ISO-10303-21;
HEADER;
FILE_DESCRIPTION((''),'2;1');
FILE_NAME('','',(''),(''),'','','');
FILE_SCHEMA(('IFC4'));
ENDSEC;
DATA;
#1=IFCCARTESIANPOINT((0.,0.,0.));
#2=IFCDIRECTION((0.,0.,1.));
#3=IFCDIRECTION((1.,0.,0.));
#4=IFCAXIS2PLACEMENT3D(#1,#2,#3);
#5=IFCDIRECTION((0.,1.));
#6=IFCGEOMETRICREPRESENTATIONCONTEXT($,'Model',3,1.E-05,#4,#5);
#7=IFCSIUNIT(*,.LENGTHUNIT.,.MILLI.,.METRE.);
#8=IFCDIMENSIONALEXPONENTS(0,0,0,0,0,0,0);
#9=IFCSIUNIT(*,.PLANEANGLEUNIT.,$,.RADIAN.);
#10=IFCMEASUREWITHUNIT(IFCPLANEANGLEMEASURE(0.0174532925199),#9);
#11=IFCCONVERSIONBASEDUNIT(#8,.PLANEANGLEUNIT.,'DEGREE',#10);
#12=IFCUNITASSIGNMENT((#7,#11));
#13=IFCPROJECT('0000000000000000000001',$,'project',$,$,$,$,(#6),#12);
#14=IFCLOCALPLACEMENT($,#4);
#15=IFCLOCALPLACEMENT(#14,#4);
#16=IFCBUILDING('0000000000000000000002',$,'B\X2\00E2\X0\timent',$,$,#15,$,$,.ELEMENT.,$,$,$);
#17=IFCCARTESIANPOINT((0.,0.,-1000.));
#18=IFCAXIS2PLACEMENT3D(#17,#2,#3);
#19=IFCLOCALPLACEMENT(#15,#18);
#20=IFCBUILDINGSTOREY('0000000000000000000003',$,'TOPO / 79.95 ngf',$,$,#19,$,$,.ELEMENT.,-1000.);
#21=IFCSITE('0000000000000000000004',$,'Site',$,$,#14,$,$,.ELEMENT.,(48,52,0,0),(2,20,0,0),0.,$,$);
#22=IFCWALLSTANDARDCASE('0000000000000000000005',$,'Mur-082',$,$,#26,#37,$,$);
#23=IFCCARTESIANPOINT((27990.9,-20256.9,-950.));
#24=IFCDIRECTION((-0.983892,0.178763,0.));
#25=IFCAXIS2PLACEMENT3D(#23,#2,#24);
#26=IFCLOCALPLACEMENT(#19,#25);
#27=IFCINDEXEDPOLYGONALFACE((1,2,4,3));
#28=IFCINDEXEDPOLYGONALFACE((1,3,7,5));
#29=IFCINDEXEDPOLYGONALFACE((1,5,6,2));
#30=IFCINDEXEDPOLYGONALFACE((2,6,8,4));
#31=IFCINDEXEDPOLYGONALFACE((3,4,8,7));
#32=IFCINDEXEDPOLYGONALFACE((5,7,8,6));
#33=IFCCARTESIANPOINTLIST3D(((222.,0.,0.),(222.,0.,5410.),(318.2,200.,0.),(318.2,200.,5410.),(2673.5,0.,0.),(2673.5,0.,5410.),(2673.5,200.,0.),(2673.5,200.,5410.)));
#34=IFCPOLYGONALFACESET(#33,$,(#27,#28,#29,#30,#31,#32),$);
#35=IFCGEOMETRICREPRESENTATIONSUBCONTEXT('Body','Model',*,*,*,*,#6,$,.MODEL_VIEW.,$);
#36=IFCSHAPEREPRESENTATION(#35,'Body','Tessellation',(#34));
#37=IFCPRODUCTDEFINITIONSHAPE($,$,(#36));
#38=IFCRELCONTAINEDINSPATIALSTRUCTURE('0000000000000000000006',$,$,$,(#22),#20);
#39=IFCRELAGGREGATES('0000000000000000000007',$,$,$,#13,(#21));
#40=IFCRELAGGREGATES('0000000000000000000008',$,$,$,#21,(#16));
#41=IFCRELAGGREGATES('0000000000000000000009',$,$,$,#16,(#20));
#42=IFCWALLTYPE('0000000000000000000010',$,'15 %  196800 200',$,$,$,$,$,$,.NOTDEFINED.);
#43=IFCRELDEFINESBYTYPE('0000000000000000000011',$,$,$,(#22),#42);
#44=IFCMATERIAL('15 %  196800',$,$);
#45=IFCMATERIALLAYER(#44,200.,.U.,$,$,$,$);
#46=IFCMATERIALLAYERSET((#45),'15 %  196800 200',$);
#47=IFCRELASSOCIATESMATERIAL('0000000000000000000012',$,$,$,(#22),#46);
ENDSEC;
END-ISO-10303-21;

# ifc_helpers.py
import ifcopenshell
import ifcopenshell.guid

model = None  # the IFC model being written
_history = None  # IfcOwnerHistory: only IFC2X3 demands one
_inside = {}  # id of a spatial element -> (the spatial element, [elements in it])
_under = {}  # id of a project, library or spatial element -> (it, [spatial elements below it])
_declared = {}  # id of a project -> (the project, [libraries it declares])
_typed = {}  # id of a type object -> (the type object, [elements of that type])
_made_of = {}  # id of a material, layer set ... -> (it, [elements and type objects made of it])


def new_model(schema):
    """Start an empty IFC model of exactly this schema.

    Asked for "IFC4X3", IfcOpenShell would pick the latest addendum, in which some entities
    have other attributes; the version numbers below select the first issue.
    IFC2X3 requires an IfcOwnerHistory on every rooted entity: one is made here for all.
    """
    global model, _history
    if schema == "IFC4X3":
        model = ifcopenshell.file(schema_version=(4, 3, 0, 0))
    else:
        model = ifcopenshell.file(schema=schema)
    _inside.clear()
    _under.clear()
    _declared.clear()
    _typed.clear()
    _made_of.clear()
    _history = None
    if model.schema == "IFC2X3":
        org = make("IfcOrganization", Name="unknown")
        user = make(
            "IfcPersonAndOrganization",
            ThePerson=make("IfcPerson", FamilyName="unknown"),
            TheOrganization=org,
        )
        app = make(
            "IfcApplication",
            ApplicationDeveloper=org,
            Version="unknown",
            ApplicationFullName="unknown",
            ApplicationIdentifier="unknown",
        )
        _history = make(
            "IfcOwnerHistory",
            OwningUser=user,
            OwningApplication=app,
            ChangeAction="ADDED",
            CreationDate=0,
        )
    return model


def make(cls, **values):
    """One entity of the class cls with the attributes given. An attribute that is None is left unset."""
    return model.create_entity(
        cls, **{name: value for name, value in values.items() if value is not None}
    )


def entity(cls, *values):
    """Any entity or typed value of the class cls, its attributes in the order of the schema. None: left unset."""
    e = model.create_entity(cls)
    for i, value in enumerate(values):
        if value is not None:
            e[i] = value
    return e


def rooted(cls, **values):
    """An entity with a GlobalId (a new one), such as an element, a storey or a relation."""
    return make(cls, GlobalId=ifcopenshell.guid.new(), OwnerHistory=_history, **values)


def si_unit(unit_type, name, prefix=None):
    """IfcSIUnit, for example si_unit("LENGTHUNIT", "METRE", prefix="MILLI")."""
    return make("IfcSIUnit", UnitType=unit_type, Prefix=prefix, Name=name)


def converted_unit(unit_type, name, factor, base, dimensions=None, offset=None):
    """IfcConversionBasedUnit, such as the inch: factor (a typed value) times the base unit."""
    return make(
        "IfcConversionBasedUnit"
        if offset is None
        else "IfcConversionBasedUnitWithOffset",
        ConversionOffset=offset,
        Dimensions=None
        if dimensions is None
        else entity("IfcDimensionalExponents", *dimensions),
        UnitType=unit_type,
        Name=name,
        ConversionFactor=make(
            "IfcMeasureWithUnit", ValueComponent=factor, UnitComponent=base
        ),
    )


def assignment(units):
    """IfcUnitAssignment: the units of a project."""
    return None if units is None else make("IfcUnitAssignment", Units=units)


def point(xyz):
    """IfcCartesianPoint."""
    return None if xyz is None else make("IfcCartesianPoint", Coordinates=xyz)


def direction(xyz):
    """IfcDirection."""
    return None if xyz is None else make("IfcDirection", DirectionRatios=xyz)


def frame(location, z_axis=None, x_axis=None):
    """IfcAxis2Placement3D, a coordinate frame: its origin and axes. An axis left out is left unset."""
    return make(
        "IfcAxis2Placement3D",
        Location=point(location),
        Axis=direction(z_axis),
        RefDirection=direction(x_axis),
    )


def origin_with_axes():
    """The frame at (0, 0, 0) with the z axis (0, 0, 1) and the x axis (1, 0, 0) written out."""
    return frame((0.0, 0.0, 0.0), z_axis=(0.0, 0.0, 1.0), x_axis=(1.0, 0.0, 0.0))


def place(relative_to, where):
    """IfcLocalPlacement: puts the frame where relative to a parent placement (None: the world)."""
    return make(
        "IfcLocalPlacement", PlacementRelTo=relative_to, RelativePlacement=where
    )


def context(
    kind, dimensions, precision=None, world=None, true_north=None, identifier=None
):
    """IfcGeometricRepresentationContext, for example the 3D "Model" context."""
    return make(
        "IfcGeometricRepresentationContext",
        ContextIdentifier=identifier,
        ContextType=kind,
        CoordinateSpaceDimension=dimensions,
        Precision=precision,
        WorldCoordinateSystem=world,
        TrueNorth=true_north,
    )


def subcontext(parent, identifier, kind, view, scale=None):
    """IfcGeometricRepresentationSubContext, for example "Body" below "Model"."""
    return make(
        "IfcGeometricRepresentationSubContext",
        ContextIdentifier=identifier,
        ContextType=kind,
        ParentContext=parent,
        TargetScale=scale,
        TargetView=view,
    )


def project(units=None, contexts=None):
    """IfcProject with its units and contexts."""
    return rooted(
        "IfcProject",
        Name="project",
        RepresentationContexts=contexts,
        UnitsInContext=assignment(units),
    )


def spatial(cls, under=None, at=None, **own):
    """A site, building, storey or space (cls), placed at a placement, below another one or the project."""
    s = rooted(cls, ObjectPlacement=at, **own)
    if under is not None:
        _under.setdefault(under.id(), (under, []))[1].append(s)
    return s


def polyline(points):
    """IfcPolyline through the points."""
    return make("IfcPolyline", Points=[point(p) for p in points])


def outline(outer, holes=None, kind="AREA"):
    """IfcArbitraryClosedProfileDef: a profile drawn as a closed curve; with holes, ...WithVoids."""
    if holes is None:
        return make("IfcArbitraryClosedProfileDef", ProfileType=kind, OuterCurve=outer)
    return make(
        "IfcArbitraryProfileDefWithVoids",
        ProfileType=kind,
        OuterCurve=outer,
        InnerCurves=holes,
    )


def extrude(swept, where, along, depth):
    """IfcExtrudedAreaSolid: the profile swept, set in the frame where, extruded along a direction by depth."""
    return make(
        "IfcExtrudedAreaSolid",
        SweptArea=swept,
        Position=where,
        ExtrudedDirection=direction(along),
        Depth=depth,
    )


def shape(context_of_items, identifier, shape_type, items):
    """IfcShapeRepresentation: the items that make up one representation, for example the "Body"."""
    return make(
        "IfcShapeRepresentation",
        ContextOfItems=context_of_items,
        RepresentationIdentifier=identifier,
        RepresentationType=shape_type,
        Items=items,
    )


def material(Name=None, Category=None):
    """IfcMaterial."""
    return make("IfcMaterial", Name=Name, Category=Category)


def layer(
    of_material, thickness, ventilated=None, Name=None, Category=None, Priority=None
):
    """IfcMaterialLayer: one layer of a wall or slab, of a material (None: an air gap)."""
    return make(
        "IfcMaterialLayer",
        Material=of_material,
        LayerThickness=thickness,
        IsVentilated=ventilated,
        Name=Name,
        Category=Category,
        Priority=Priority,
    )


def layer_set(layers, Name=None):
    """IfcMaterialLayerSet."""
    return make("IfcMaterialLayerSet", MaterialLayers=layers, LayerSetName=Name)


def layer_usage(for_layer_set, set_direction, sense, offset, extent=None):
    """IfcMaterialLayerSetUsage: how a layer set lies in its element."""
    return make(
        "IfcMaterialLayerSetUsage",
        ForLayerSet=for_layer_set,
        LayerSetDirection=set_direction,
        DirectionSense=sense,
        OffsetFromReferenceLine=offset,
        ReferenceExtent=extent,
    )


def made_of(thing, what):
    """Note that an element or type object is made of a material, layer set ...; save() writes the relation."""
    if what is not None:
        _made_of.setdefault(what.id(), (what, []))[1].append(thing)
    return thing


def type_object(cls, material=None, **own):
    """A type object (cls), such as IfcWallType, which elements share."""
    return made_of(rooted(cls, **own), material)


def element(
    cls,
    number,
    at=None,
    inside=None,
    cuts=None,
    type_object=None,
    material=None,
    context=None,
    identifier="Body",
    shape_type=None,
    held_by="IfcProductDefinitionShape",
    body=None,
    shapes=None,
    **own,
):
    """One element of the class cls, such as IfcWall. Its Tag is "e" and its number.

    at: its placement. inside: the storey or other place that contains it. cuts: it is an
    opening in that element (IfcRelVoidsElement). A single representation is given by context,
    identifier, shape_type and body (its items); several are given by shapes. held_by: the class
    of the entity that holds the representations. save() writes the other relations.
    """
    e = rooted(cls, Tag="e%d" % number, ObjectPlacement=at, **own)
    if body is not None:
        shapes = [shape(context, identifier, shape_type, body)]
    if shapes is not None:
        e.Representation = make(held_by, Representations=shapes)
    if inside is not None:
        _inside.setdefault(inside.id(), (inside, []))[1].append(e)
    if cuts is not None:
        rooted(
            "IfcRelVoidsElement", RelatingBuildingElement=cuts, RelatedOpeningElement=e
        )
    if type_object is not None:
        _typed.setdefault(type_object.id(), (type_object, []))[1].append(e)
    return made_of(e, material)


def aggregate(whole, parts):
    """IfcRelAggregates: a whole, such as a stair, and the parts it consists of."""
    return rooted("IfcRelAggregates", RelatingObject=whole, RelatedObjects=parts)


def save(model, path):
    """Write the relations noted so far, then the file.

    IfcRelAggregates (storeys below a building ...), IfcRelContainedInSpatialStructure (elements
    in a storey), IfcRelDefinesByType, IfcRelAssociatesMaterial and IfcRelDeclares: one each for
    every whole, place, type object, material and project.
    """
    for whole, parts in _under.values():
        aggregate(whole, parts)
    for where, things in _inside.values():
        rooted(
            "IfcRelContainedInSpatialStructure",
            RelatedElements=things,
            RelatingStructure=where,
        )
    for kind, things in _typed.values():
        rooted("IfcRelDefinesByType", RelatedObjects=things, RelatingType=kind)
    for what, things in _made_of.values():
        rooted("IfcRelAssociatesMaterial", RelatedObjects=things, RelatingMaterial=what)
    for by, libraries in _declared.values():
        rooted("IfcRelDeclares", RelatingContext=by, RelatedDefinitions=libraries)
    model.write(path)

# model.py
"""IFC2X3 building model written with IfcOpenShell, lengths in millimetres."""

from ifc_helpers import new_model, entity, si_unit, converted_unit, direction, frame, origin_with_axes, place, context, subcontext, project, spatial, polyline, outline, extrude, material, layer, layer_set, layer_usage, type_object, element, save


model = new_model("IFC2X3")

# Units and contexts
model_context = context("Model", 3, precision=1e-05, world=origin_with_axes(), true_north=direction((0.0, 1.0)))
body_context = subcontext(model_context, "Body", "Model", "MODEL_VIEW")
ifc_project = project(units=[si_unit("LENGTHUNIT", "METRE", prefix="MILLI"), converted_unit("PLANEANGLEUNIT", "DEGREE", entity("IfcPlaneAngleMeasure", 0.0174532925199), si_unit("PLANEANGLEUNIT", "RADIAN"), dimensions=[0, 0, 0, 0, 0, 0, 0])], contexts=[model_context])

# Site, building, storey
site_placement = place(None, origin_with_axes())
site = spatial("IfcSite", under=ifc_project, at=site_placement, Name="Site", CompositionType="ELEMENT", RefLatitude=(48, 52, 0, 0), RefLongitude=(2, 20, 0, 0), RefElevation=0.0)
building_placement = place(site_placement, origin_with_axes())
building = spatial("IfcBuilding", under=site, at=building_placement, Name="Bâtiment", CompositionType="ELEMENT")
storey_placement = place(building_placement, frame((0.0, 0.0, -1000.0), z_axis=(0.0, 0.0, 1.0), x_axis=(1.0, 0.0, 0.0)))
storey = spatial("IfcBuildingStorey", under=building, at=storey_placement, Name="TOPO / 79.95 ngf", CompositionType="ELEMENT", Elevation=-1000.0)

# Wall
ifc_material_1 = material(Name="15 %  196800")
ifc_layer_1 = layer(ifc_material_1, 200.0, ventilated="UNKNOWN")
ifc_layer_set_1 = layer_set([ifc_layer_1], Name="15 %  196800 200")
ifc_layer_usage_1 = layer_usage(ifc_layer_set_1, "AXIS2", "NEGATIVE", 200.0)
wall_type_1 = type_object("IfcWallType", Name="15 %  196800 200", PredefinedType="NOTDEFINED")
wall_1_placement = place(storey_placement, frame((27990.9, -20256.9, -950.0), z_axis=(0.0, 0.0, 1.0), x_axis=(-0.983892, 0.178763, 0.0)))
element("IfcWallStandardCase", 1, at=wall_1_placement, inside=storey, type_object=wall_type_1, material=ifc_layer_usage_1, Name="Mur-082", context=body_context, shape_type="SweptSolid", body=[
    extrude(outline(polyline([(222.0, 0.0), (2673.5, 0.0), (2673.5, 200.0), (318.2, 200.0), (222.0, 0.0)])), origin_with_axes(), (0.0, 0.0, 1.0), 5410.0),
])

save(model, "model.ifc")
